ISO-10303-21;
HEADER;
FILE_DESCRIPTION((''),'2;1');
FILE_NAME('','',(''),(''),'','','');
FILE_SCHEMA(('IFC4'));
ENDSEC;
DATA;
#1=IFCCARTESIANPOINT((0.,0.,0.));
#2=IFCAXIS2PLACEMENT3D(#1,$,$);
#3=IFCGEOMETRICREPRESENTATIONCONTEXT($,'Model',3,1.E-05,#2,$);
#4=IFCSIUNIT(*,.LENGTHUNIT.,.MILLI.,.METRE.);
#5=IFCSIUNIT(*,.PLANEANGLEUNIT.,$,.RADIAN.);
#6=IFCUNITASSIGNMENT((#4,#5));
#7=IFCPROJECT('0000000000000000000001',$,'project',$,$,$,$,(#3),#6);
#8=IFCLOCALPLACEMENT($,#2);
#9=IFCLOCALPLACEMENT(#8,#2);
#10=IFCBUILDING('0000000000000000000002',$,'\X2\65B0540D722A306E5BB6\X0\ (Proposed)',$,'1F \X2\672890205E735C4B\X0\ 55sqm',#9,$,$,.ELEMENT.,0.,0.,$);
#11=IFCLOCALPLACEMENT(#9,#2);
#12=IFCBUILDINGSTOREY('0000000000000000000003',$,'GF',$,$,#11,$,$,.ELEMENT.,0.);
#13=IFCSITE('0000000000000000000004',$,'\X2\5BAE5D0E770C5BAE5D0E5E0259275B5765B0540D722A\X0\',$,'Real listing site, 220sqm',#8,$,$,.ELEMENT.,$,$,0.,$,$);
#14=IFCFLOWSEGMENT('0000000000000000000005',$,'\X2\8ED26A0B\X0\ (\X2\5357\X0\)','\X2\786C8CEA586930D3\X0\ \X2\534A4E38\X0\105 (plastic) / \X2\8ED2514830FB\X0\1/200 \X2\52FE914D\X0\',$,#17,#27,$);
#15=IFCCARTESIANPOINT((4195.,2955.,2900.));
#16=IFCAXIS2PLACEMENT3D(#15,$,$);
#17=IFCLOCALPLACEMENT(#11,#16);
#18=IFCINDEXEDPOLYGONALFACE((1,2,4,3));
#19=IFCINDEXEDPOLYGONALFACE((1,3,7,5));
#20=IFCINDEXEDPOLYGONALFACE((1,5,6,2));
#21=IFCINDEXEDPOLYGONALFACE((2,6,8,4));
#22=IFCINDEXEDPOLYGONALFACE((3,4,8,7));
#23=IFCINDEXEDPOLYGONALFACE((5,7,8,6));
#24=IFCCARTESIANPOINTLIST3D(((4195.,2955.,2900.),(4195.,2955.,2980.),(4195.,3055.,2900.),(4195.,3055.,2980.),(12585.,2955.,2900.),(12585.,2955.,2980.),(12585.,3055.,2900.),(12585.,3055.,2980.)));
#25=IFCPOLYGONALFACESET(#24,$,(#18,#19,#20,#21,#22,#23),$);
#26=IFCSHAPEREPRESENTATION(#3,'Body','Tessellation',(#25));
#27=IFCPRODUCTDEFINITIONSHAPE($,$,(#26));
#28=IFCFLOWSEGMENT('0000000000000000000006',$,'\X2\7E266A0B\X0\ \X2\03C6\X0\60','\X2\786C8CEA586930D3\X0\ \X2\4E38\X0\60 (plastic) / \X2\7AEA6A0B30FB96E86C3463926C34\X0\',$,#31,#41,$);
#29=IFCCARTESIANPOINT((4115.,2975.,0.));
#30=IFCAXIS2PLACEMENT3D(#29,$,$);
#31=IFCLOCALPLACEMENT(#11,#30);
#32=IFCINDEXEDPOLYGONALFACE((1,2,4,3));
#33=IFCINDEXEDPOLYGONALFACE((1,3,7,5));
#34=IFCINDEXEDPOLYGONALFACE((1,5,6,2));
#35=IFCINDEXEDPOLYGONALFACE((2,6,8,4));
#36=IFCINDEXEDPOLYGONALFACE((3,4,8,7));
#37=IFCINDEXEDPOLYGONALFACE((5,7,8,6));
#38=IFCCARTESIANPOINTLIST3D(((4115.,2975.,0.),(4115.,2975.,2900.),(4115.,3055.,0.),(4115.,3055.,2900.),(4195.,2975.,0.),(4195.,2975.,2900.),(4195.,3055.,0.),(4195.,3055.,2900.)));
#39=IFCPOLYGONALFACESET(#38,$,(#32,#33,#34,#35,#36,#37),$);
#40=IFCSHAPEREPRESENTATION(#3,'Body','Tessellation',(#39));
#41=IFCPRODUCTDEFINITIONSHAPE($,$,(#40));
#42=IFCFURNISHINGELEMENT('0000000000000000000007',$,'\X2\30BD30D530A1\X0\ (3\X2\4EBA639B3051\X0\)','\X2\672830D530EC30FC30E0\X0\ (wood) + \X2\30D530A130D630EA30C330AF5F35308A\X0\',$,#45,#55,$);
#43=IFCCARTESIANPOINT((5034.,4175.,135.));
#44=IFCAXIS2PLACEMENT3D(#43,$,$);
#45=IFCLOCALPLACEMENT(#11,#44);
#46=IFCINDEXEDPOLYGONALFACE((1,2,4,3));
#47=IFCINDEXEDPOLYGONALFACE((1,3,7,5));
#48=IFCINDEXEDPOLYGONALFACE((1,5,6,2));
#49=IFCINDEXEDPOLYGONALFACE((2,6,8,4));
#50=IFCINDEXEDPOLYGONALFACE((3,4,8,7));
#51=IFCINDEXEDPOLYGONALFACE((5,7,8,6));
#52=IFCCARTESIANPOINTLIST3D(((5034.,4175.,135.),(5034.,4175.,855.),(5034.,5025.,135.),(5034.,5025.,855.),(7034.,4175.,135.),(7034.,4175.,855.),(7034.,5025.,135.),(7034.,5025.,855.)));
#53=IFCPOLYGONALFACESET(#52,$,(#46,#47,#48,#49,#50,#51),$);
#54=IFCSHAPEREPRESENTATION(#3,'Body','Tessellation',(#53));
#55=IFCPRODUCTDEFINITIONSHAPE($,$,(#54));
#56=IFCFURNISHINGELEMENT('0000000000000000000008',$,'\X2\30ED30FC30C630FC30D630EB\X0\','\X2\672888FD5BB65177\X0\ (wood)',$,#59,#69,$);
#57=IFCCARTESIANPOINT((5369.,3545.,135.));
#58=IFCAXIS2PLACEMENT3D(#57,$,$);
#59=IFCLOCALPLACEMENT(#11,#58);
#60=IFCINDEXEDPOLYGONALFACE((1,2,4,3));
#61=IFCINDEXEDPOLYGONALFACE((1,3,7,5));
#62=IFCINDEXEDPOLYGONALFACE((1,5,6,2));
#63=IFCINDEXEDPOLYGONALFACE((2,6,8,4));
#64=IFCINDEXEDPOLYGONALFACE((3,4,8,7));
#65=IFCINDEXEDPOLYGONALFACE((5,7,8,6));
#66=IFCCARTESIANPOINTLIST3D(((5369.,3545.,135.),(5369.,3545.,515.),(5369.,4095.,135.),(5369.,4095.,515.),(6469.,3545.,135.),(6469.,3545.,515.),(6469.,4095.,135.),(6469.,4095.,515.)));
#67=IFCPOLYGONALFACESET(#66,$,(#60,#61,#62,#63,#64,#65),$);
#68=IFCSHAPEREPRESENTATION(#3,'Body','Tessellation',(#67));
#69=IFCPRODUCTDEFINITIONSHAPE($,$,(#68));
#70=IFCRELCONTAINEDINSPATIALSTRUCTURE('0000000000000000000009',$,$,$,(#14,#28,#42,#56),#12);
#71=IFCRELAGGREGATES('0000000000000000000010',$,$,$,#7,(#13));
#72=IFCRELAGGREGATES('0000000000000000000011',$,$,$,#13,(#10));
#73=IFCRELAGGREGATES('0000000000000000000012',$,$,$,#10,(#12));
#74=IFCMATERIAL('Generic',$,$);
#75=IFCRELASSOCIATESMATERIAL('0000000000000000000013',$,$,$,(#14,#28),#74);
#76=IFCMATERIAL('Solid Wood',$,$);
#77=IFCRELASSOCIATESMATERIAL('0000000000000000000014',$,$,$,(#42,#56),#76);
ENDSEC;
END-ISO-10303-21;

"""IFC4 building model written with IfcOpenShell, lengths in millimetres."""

from ifc_helpers import new_model, si_unit, frame, frame_2d, origin, place, context, project, spatial, rectangle, extrude, material, element, save


model = new_model("IFC4")

# Units and contexts
model_context = context("Model", 3, precision=1e-05, world=origin())
ifc_project = project(units=[si_unit("LENGTHUNIT", "METRE", prefix="MILLI"), si_unit("PLANEANGLEUNIT", "RADIAN")], contexts=[model_context])

# Site, building, storey
site_placement = place(None, origin())
site = spatial("IfcSite", under=ifc_project, at=site_placement, Name="宮崎県宮崎市大字新名爪", ObjectType="Real listing site, 220sqm", CompositionType="ELEMENT", RefElevation=0.0)
building_placement = place(site_placement, origin())
building = spatial("IfcBuilding", under=site, at=building_placement, Name="新名爪の家 (Proposed)", ObjectType="1F 木造平屋 55sqm", CompositionType="ELEMENT", ElevationOfRefHeight=0.0, ElevationOfTerrain=0.0)
storey_placement = place(building_placement, origin())
storey = spatial("IfcBuildingStorey", under=building, at=storey_placement, Name="GF", CompositionType="ELEMENT", Elevation=0.0)

# Shared definitions
ifc_material_1 = material(Name="Solid Wood")

# Shared definitions
ifc_material_2 = material(Name="Generic")

# Flow segments
flow_segment_1_placement = place(storey_placement, frame((4195.0, 2955.0, 2900.0)))
element("IfcFlowSegment", 1, at=flow_segment_1_placement, inside=storey, material=ifc_material_2, Name="軒樋 (南)", Description="硬質塩ビ 半丸105 (plastic) / 軒先・1/200 勾配", context=model_context, shape_type="SweptSolid", body=[
    extrude(rectangle(XDim=8390.0, YDim=100.0, at=frame_2d((4195.0, 50.0))), frame((4195.0, 2955.0, 2900.0)), (0.0, 0.0, 1.0), 80.0),
])
flow_segment_2_placement = place(storey_placement, frame((4115.0, 2975.0, 0.0)))
element("IfcFlowSegment", 2, at=flow_segment_2_placement, inside=storey, material=ifc_material_2, Name="縦樋 φ60", Description="硬質塩ビ 丸60 (plastic) / 竪樋・雨水排水", context=model_context, shape_type="SweptSolid", body=[
    extrude(rectangle(XDim=80.0, YDim=80.0, at=frame_2d((40.0, 40.0))), frame((4115.0, 2975.0, 0.0)), (0.0, 0.0, 1.0), 2900.0),
])

# Furnishing elements
furnishing_1_placement = place(storey_placement, frame((5034.0, 4175.0, 135.0)))
element("IfcFurnishingElement", 3, at=furnishing_1_placement, inside=storey, material=ifc_material_1, Name="ソファ (3人掛け)", Description="木フレーム (wood) + ファブリック張り", context=model_context, shape_type="SweptSolid", body=[
    extrude(rectangle(XDim=2000.0, YDim=850.0, at=frame_2d((1000.0, 425.0))), frame((5034.0, 4175.0, 135.0)), (0.0, 0.0, 1.0), 720.0),
])
furnishing_2_placement = place(storey_placement, frame((5369.0, 3545.0, 135.0)))
element("IfcFurnishingElement", 4, at=furnishing_2_placement, inside=storey, material=ifc_material_1, Name="ローテーブル", Description="木製家具 (wood)", context=model_context, shape_type="SweptSolid", body=[
    extrude(rectangle(XDim=1100.0, YDim=550.0, at=frame_2d((550.0, 275.0))), frame((5369.0, 3545.0, 135.0)), (0.0, 0.0, 1.0), 380.0),
])

save(model, "model.ifc")
